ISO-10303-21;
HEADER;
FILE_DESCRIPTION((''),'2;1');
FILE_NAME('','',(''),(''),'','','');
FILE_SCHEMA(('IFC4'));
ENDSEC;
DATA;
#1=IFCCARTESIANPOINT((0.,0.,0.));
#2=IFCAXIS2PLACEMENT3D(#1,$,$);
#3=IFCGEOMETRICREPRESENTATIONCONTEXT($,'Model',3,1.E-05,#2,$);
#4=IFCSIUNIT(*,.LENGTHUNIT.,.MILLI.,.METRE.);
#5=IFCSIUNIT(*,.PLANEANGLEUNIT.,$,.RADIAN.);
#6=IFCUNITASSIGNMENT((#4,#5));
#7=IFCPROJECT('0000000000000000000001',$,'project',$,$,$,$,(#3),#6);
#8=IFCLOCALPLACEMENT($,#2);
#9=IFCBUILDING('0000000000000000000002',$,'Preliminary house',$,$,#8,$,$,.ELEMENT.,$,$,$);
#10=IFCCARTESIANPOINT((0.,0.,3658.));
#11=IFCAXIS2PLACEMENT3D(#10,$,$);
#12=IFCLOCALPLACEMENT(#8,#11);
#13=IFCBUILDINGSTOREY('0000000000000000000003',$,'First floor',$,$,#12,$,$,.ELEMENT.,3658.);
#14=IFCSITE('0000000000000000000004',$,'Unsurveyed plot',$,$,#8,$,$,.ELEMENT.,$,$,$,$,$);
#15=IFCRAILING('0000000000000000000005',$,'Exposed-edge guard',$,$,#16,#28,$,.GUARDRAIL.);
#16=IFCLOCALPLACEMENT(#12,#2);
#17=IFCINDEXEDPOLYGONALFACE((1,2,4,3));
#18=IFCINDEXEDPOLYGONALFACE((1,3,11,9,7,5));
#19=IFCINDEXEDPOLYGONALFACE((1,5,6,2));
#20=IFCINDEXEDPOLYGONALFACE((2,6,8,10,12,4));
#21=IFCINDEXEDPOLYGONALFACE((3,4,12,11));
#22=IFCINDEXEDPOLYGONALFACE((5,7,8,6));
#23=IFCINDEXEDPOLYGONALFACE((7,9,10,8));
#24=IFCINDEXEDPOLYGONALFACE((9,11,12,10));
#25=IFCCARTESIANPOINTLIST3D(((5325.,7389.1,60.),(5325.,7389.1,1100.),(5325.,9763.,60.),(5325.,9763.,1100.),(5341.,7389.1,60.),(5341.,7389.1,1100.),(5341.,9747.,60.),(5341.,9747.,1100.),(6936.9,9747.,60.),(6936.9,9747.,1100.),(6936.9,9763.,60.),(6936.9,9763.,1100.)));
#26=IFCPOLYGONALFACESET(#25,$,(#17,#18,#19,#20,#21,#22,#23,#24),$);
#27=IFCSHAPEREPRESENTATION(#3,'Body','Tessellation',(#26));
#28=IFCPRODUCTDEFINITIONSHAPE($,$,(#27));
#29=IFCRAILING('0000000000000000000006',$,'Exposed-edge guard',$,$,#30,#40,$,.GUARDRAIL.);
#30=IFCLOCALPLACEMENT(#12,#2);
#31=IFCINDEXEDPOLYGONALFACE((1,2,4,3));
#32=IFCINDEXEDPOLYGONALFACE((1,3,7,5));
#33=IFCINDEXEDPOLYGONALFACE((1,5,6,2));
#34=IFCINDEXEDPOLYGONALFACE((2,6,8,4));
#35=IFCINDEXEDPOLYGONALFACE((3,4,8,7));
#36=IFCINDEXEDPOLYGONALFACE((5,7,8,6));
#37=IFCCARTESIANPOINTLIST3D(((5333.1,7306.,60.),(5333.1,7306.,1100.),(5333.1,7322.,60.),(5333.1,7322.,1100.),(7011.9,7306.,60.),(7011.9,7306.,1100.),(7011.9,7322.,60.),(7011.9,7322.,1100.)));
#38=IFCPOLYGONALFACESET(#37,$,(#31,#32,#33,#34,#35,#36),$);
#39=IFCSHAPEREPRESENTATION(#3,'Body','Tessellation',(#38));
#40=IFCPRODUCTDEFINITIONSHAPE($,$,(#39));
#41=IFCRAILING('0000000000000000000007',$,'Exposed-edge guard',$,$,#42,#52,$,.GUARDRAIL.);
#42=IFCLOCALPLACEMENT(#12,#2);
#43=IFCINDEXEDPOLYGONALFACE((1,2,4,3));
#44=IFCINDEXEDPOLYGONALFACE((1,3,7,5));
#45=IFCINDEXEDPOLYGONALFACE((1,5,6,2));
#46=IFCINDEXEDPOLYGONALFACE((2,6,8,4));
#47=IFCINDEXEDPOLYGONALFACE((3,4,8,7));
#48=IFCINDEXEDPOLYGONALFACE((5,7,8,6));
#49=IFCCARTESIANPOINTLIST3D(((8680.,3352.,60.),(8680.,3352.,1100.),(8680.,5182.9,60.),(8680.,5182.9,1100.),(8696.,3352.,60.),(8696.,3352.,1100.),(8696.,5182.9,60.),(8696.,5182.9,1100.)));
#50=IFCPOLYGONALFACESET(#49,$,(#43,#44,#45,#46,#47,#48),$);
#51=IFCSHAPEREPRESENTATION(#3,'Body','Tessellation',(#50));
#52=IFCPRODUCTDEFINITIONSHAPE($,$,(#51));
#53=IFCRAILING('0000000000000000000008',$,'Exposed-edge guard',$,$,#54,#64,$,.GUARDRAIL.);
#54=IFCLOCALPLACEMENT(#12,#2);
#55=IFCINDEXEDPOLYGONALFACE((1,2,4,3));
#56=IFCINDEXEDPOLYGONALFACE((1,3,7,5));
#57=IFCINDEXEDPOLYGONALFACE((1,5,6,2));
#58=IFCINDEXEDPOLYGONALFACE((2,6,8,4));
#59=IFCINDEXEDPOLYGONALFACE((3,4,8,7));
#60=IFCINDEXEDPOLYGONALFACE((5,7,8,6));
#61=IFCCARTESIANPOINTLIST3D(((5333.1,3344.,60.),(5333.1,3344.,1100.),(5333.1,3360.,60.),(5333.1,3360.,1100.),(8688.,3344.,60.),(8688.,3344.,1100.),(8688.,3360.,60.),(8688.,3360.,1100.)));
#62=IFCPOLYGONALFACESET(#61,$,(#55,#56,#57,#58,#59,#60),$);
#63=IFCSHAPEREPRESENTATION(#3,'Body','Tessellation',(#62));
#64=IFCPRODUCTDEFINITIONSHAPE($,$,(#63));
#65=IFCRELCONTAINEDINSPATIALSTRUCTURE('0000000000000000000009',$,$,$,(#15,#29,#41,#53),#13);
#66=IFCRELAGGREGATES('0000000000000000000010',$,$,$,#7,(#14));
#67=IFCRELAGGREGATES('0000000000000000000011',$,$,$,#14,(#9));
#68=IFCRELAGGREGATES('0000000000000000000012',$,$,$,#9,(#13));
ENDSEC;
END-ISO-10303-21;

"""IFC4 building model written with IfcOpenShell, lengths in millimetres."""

from ifc_helpers import new_model, si_unit, frame, origin, place, context, project, spatial, polyline, outline, extrude, element, save


model = new_model("IFC4")

# Units and contexts
model_context = context("Model", 3, precision=1e-05, world=origin())
ifc_project = project(units=[si_unit("LENGTHUNIT", "METRE", prefix="MILLI"), si_unit("PLANEANGLEUNIT", "RADIAN")], contexts=[model_context])

# Site, building, storey
placement_1 = place(None, origin())
site = spatial("IfcSite", under=ifc_project, at=placement_1, Name="Unsurveyed plot", CompositionType="ELEMENT")
building = spatial("IfcBuilding", under=site, at=placement_1, Name="Preliminary house", CompositionType="ELEMENT")
placement_2 = place(placement_1, frame((0.0, 0.0, 3658.0)))
storey = spatial("IfcBuildingStorey", under=building, at=placement_2, Name="First floor", CompositionType="ELEMENT", Elevation=3658.0)

# Railings
element("IfcRailing", 1, at=placement_2, inside=storey, Name="Exposed-edge guard", PredefinedType="GUARDRAIL", context=model_context, shape_type="SweptSolid", body=[
    extrude(outline(polyline([(5341.0, 9747.0), (5341.0, 7389.1), (5325.0, 7389.1), (5325.0, 9763.0), (6936.9, 9763.0), (6936.9, 9747.0), (5341.0, 9747.0)])), frame((0.0, 0.0, 60.0)), (0.0, 0.0, 1.0), 1040.0),
])
element("IfcRailing", 2, at=placement_2, inside=storey, Name="Exposed-edge guard", PredefinedType="GUARDRAIL", context=model_context, shape_type="SweptSolid", body=[
    extrude(outline(polyline([(7011.9, 7322.0), (7011.9, 7306.0), (5333.1, 7306.0), (5333.1, 7322.0), (7011.9, 7322.0)])), frame((0.0, 0.0, 60.0)), (0.0, 0.0, 1.0), 1040.0),
])
element("IfcRailing", 3, at=placement_2, inside=storey, Name="Exposed-edge guard", PredefinedType="GUARDRAIL", context=model_context, shape_type="SweptSolid", body=[
    extrude(outline(polyline([(8680.0, 5182.9), (8696.0, 5182.9), (8696.0, 3352.0), (8680.0, 3352.0), (8680.0, 5182.9)])), frame((0.0, 0.0, 60.0)), (0.0, 0.0, 1.0), 1040.0),
])
element("IfcRailing", 4, at=placement_2, inside=storey, Name="Exposed-edge guard", PredefinedType="GUARDRAIL", context=model_context, shape_type="SweptSolid", body=[
    extrude(outline(polyline([(8688.0, 3360.0), (8688.0, 3344.0), (5333.1, 3344.0), (5333.1, 3360.0), (8688.0, 3360.0)])), frame((0.0, 0.0, 60.0)), (0.0, 0.0, 1.0), 1040.0),
])

save(model, "model.ifc")
